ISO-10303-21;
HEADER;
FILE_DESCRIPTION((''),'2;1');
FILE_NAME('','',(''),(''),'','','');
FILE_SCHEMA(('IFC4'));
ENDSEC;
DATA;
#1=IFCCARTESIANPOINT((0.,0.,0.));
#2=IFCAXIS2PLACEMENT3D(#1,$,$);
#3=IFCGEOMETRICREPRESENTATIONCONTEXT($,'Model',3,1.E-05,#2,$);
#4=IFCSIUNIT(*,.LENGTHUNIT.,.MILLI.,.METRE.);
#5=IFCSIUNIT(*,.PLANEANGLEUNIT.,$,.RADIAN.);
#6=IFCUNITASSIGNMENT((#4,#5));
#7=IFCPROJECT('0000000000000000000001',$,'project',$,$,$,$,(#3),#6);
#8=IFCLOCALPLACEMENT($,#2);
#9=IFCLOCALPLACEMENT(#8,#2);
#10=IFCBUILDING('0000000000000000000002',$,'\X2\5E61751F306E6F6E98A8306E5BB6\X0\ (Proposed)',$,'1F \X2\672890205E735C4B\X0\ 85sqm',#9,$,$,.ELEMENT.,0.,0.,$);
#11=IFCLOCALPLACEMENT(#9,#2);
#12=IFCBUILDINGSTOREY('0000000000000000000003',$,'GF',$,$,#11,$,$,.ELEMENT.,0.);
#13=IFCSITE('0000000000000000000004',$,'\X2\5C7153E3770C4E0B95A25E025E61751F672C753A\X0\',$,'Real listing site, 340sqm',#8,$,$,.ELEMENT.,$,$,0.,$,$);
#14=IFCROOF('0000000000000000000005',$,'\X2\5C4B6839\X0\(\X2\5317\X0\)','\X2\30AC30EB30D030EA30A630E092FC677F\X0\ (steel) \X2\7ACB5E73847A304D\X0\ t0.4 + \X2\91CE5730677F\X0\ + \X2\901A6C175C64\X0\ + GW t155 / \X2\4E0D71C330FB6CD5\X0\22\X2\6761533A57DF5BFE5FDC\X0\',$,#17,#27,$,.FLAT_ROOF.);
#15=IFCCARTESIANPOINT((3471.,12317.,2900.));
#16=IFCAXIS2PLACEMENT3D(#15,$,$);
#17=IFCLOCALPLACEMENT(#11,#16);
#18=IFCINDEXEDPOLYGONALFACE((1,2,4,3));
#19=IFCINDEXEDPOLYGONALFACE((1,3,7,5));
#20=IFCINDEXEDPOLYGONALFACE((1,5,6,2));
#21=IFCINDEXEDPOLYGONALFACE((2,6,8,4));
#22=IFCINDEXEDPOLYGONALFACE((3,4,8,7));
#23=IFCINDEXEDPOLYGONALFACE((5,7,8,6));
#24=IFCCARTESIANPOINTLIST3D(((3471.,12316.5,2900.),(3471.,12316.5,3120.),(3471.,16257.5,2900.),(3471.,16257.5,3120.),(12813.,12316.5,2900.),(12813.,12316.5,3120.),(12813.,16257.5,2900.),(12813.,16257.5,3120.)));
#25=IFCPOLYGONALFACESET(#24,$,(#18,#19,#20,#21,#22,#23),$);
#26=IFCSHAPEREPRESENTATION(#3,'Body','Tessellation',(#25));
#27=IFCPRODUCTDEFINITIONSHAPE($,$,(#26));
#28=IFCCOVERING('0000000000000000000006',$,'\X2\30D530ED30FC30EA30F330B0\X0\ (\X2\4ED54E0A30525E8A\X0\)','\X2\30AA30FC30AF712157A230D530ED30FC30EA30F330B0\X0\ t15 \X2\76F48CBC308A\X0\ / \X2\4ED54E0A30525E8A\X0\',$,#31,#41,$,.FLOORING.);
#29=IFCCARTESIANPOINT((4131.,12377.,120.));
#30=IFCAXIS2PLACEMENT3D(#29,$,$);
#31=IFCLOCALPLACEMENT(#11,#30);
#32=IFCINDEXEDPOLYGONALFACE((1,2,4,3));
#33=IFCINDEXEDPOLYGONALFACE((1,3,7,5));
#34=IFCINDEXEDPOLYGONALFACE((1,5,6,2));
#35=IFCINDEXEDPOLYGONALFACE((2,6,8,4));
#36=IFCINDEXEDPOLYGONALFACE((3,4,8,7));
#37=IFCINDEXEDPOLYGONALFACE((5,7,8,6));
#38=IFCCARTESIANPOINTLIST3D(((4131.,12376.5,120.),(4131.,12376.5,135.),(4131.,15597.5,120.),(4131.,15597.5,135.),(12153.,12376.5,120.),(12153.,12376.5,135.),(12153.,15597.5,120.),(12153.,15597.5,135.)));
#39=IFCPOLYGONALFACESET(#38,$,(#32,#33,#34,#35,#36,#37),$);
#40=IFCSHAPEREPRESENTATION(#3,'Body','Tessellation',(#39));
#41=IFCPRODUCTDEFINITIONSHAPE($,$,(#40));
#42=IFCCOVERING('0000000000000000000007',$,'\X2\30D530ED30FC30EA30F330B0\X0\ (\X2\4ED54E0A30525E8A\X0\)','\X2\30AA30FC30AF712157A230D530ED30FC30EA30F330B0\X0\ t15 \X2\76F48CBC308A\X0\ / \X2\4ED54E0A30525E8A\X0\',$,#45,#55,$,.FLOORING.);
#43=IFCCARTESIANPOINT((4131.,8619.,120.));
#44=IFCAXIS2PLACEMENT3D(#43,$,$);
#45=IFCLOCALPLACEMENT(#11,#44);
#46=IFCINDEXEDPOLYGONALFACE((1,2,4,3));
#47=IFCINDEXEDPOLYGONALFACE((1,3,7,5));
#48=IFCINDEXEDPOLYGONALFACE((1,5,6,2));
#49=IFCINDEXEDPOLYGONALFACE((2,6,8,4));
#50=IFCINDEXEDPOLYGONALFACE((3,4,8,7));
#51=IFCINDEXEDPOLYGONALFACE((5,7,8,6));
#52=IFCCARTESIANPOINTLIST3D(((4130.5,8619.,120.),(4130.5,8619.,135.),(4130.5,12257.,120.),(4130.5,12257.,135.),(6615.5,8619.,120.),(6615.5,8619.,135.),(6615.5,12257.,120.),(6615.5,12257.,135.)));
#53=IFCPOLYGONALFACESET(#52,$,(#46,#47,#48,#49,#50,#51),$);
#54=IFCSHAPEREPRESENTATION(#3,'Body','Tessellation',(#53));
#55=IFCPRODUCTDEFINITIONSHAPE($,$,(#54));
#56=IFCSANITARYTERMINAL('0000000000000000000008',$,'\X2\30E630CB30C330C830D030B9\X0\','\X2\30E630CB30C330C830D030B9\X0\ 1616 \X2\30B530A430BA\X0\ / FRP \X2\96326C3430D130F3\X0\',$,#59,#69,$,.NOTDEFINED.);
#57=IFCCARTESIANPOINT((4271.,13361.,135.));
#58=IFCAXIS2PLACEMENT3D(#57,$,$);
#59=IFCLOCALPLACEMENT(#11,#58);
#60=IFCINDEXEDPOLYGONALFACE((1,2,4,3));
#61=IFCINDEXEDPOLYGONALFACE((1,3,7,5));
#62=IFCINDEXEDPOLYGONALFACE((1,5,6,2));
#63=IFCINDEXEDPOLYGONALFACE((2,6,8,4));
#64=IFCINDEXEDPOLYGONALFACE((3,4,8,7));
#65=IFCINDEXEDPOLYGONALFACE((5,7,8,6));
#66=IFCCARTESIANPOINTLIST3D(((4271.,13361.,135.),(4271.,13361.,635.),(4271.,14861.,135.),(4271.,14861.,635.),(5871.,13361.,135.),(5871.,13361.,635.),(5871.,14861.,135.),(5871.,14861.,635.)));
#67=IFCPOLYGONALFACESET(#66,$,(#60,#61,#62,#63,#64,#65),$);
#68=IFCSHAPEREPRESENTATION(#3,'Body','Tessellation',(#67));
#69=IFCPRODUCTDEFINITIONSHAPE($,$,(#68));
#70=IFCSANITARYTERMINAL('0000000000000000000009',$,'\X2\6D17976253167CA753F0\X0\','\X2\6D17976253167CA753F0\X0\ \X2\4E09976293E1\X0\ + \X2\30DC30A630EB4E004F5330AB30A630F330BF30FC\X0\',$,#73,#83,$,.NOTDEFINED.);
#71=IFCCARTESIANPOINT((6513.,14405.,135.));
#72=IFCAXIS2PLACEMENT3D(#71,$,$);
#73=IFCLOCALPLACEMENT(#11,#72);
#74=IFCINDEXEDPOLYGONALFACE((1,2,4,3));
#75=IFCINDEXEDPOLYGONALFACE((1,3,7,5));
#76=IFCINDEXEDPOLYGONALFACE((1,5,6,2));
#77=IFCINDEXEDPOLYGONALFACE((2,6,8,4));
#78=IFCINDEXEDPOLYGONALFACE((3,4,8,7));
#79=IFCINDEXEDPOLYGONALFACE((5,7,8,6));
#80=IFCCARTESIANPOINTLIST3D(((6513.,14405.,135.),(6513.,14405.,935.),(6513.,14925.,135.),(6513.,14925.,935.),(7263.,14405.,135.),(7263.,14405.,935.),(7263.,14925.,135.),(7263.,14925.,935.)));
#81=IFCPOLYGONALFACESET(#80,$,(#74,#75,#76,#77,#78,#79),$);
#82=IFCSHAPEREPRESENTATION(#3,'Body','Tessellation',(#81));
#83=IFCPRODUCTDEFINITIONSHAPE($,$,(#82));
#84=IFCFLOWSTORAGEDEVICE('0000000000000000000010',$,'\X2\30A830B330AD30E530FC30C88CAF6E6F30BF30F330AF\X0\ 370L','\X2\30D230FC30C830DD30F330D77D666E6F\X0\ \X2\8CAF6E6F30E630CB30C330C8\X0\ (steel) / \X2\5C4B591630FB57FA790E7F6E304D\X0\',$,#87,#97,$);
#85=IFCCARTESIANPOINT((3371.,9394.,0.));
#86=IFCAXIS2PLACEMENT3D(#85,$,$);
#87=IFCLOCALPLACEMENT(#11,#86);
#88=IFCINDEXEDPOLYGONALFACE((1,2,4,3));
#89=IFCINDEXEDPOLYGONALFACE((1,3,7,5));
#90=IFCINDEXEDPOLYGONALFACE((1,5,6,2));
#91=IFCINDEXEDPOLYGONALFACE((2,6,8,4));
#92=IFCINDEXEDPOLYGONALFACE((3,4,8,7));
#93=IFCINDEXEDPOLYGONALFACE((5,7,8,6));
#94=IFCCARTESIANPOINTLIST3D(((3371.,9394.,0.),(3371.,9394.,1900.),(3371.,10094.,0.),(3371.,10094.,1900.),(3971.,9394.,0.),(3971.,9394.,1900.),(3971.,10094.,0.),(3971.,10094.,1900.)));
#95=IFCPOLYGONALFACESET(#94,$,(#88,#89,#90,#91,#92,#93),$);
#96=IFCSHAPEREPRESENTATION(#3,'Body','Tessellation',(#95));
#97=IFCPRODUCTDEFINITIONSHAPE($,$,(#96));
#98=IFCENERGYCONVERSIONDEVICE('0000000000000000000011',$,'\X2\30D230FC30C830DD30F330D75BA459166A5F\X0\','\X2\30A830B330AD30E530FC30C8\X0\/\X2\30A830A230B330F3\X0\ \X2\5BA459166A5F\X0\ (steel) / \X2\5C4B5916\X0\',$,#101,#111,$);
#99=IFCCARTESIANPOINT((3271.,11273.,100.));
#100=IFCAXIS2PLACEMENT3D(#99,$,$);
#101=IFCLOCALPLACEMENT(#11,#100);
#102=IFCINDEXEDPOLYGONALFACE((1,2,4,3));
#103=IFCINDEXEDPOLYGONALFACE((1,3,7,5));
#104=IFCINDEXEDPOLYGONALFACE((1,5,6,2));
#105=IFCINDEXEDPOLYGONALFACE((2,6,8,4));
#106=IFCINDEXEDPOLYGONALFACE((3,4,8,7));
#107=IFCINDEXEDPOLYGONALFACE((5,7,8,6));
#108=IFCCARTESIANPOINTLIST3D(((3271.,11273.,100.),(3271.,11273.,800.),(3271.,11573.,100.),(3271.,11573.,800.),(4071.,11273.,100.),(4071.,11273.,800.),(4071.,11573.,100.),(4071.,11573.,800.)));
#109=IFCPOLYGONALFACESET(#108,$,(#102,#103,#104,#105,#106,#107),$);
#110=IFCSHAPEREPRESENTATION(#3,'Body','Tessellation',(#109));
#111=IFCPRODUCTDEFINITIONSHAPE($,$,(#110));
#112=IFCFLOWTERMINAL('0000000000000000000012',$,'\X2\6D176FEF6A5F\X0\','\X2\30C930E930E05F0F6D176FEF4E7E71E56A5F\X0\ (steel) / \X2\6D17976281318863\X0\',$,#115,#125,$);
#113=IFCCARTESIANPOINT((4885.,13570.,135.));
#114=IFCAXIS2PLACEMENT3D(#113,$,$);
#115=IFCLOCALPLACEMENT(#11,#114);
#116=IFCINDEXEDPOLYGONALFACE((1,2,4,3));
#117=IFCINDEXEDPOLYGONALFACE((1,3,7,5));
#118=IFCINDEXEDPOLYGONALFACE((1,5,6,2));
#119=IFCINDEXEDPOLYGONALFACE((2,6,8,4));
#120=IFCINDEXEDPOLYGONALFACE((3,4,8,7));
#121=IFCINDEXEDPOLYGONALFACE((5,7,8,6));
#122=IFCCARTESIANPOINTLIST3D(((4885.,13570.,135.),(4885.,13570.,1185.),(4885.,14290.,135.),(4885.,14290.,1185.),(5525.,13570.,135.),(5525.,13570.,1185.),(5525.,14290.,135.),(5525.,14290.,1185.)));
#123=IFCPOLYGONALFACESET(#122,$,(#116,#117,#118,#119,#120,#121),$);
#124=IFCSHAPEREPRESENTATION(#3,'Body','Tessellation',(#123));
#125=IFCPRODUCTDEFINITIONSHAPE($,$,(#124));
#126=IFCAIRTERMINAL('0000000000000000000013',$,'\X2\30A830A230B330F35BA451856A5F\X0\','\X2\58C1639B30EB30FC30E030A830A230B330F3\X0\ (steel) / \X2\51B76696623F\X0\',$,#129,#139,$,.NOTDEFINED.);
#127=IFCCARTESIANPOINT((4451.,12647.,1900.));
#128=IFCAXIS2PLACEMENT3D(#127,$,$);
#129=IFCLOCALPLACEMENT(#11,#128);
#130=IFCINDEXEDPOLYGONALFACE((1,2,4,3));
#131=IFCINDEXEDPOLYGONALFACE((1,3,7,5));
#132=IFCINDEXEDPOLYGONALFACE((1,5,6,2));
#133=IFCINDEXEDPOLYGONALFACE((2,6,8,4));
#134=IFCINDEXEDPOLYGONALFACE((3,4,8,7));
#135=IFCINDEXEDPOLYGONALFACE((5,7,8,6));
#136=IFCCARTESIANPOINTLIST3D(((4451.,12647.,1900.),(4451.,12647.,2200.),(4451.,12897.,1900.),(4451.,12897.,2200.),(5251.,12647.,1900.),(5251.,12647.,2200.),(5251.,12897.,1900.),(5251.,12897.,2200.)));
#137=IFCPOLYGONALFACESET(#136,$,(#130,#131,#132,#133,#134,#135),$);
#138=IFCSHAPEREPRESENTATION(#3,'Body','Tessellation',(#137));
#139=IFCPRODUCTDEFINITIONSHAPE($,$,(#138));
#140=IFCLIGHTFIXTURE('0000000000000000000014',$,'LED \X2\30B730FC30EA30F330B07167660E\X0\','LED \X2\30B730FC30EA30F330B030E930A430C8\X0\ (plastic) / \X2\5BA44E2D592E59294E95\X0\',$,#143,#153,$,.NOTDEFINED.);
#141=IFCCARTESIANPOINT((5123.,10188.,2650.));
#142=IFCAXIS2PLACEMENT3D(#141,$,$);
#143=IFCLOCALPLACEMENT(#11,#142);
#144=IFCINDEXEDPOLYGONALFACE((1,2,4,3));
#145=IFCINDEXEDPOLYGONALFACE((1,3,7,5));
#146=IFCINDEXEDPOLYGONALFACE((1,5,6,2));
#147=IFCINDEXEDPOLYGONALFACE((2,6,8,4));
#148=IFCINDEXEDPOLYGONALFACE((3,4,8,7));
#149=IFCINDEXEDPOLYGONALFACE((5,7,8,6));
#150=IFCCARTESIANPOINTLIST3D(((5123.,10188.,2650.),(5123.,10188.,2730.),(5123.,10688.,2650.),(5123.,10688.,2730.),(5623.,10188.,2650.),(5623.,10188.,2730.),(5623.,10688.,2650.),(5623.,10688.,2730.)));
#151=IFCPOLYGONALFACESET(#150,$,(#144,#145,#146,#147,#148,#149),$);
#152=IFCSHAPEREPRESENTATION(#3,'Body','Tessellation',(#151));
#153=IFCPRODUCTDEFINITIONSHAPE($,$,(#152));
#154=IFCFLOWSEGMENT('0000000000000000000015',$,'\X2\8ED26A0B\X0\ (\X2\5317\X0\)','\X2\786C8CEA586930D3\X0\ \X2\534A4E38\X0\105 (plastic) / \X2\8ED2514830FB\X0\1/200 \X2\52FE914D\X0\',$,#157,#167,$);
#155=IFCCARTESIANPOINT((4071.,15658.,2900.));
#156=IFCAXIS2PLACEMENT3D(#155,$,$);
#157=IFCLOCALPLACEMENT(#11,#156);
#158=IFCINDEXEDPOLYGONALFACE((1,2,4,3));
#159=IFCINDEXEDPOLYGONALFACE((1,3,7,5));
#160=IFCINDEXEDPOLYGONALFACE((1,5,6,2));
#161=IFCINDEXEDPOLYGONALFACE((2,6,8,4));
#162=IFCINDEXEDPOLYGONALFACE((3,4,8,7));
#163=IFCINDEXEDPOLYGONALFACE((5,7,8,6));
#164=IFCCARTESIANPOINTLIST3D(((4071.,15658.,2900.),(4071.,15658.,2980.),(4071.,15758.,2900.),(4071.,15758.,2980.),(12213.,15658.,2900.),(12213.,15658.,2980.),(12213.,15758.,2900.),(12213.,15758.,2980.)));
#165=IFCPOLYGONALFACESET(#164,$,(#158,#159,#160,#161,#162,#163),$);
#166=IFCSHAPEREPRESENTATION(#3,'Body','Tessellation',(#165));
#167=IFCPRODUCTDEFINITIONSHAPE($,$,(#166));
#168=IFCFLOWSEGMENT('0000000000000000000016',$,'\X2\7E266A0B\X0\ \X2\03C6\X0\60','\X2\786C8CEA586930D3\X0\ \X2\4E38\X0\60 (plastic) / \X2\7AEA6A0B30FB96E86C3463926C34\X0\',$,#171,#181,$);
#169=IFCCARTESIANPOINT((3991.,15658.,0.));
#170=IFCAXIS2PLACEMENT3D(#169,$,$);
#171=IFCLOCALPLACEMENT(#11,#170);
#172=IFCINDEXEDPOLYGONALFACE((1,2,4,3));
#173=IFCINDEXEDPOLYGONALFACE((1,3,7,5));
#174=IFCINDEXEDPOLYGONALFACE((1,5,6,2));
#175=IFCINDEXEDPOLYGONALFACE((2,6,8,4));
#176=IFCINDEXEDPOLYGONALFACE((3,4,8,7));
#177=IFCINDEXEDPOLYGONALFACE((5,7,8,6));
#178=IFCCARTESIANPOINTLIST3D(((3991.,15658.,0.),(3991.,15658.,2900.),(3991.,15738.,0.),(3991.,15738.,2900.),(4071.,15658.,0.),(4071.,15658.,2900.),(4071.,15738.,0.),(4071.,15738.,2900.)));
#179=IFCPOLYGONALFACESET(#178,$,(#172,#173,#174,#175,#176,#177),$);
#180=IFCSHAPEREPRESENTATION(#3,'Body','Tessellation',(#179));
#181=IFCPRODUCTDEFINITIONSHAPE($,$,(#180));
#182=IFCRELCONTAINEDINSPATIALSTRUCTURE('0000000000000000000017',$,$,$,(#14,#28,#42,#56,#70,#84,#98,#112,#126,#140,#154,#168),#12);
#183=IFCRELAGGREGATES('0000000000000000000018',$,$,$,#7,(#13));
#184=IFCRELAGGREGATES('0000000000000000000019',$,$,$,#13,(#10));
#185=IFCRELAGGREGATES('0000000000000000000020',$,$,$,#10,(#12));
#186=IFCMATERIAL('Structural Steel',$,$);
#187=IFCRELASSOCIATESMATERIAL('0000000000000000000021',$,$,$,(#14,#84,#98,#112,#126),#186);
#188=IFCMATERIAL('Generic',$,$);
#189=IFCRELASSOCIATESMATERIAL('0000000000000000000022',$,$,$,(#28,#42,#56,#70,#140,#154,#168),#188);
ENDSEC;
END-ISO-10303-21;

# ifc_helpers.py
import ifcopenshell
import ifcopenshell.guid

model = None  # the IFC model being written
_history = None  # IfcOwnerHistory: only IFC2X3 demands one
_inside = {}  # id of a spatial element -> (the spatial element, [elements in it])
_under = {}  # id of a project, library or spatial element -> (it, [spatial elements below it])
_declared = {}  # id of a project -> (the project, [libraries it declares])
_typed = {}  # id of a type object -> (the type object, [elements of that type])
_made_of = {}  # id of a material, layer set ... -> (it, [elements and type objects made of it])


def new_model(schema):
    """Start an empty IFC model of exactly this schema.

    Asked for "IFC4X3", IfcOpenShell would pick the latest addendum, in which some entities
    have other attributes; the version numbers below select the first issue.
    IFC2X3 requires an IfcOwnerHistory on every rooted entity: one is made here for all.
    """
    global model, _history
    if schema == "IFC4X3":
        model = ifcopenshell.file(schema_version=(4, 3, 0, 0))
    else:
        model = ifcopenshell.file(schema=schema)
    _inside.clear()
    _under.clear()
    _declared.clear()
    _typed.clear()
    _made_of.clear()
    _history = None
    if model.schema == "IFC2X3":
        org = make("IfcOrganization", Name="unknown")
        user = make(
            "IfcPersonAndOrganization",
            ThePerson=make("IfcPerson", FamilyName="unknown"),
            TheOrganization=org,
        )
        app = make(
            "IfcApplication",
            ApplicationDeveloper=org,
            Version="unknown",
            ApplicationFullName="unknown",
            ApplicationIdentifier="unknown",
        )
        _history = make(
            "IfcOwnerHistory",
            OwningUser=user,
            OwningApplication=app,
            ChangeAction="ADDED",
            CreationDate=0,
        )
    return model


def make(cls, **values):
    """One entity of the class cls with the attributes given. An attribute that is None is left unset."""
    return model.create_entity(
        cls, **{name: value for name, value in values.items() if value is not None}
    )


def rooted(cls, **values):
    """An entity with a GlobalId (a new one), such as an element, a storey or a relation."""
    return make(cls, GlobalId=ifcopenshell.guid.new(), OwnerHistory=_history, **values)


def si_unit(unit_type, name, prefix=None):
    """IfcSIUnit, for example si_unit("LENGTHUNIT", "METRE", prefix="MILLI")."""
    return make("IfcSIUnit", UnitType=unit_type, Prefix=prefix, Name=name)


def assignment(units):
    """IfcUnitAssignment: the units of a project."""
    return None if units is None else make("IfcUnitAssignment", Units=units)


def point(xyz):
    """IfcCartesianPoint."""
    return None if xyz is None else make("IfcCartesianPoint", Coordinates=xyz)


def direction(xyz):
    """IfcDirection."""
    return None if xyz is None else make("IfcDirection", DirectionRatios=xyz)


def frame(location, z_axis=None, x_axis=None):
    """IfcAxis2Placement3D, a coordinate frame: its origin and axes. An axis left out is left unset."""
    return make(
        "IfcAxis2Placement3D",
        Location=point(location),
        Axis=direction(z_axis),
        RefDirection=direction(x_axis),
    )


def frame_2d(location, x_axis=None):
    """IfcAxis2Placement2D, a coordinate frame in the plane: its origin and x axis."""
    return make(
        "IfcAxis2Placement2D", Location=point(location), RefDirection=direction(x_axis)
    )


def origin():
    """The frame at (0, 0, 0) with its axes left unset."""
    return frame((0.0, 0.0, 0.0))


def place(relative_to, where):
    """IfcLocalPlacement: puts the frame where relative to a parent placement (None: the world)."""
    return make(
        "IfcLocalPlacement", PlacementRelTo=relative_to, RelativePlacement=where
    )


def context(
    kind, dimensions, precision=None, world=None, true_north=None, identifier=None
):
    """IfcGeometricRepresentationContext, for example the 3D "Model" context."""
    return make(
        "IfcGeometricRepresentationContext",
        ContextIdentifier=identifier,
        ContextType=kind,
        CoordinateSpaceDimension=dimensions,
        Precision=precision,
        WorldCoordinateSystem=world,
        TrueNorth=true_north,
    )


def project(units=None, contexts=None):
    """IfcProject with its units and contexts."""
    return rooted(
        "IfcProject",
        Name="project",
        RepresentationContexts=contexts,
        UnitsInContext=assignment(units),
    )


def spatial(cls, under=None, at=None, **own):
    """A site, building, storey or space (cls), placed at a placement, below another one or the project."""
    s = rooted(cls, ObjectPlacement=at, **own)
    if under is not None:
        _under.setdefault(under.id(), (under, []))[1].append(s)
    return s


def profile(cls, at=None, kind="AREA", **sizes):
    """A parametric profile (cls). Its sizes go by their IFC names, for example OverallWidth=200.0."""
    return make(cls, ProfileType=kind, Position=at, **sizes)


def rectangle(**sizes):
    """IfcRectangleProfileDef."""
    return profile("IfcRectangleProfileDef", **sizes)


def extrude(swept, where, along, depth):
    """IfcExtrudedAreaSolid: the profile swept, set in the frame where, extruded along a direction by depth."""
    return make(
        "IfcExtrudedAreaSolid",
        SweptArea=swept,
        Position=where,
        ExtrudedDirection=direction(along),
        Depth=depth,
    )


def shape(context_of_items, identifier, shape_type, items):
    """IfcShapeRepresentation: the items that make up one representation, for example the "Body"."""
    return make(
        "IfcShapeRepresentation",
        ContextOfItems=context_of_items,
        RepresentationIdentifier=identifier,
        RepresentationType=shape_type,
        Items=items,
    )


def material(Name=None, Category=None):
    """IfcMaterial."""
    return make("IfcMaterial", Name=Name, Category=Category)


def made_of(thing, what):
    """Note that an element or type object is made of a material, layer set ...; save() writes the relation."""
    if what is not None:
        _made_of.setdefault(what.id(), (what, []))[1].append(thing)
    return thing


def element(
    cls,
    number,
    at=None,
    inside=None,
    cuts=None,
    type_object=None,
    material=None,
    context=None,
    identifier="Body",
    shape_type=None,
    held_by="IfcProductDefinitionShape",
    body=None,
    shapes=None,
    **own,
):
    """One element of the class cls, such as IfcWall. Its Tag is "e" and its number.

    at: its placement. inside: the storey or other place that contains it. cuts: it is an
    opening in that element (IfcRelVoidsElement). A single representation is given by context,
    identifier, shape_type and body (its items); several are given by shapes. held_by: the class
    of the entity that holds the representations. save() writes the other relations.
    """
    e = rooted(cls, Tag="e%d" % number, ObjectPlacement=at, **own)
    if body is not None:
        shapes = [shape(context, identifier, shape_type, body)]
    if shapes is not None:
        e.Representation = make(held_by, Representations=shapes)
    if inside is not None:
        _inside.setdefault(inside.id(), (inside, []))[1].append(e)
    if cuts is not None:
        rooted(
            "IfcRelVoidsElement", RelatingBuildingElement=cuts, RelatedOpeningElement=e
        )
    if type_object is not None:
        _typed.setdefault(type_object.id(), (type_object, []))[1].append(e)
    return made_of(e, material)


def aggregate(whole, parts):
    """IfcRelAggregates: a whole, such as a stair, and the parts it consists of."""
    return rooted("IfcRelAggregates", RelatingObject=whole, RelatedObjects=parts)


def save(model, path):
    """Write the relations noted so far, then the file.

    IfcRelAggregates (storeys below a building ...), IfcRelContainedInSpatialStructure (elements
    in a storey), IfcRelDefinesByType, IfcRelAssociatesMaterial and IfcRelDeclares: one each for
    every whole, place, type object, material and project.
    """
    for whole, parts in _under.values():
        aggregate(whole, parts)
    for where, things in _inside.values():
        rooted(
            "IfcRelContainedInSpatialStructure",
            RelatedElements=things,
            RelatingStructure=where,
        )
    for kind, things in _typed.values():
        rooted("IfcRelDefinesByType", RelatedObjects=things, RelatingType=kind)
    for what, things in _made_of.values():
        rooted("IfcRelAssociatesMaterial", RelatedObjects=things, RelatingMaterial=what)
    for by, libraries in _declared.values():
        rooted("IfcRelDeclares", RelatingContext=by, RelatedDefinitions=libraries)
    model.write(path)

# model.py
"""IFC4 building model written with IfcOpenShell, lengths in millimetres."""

from ifc_helpers import new_model, si_unit, frame, frame_2d, origin, place, context, project, spatial, rectangle, extrude, material, element, save


model = new_model("IFC4")

# Units and contexts
model_context = context("Model", 3, precision=1e-05, world=origin())
ifc_project = project(units=[si_unit("LENGTHUNIT", "METRE", prefix="MILLI"), si_unit("PLANEANGLEUNIT", "RADIAN")], contexts=[model_context])

# Site, building, storey
site_placement = place(None, origin())
site = spatial("IfcSite", under=ifc_project, at=site_placement, Name="山口県下関市幡生本町", ObjectType="Real listing site, 340sqm", CompositionType="ELEMENT", RefElevation=0.0)
building_placement = place(site_placement, origin())
building = spatial("IfcBuilding", under=site, at=building_placement, Name="幡生の潮風の家 (Proposed)", ObjectType="1F 木造平屋 85sqm", CompositionType="ELEMENT", ElevationOfRefHeight=0.0, ElevationOfTerrain=0.0)
storey_placement = place(building_placement, origin())
storey = spatial("IfcBuildingStorey", under=building, at=storey_placement, Name="GF", CompositionType="ELEMENT", Elevation=0.0)

# Roof
ifc_material_1 = material(Name="Structural Steel")
roof_placement = place(storey_placement, frame((3471.0, 12317.0, 2900.0)))
element("IfcRoof", 1, at=roof_placement, inside=storey, material=ifc_material_1, Name="屋根(北)", Description="ガルバリウム鋼板 (steel) 立平葺き t0.4 + 野地板 + 通気層 + GW t155 / 不燃・法22条区域対応", PredefinedType="FLAT_ROOF", context=model_context, shape_type="SweptSolid", body=[
    extrude(rectangle(XDim=9342.0, YDim=3941.0, at=frame_2d((4671.0, 1970.0))), frame((3471.0, 12317.0, 2900.0)), (0.0, 0.0, 1.0), 220.0),
])

# Coverings
ifc_material_2 = material(Name="Generic")
covering_1_placement = place(storey_placement, frame((4131.0, 12377.0, 120.0)))
element("IfcCovering", 2, at=covering_1_placement, inside=storey, material=ifc_material_2, Name="フローリング (仕上げ床)", Description="オーク無垢フローリング t15 直貼り / 仕上げ床", PredefinedType="FLOORING", context=model_context, shape_type="SweptSolid", body=[
    extrude(rectangle(XDim=8022.0, YDim=3221.0, at=frame_2d((4011.0, 1610.0))), frame((4131.0, 12377.0, 120.0)), (0.0, 0.0, 1.0), 15.0),
])
covering_2_placement = place(storey_placement, frame((4131.0, 8619.0, 120.0)))
element("IfcCovering", 3, at=covering_2_placement, inside=storey, material=ifc_material_2, Name="フローリング (仕上げ床)", Description="オーク無垢フローリング t15 直貼り / 仕上げ床", PredefinedType="FLOORING", context=model_context, shape_type="SweptSolid", body=[
    extrude(rectangle(XDim=2485.0, YDim=3638.0, at=frame_2d((1242.0, 1819.0))), frame((4131.0, 8619.0, 120.0)), (0.0, 0.0, 1.0), 15.0),
])

# Sanitary terminals
sanitary_terminal_1_placement = place(storey_placement, frame((4271.0, 13361.0, 135.0)))
element("IfcSanitaryTerminal", 4, at=sanitary_terminal_1_placement, inside=storey, material=ifc_material_2, Name="ユニットバス", Description="ユニットバス 1616 サイズ / FRP 防水パン", PredefinedType="NOTDEFINED", context=model_context, shape_type="SweptSolid", body=[
    extrude(rectangle(XDim=1600.0, YDim=1500.0, at=frame_2d((800.0, 750.0))), frame((4271.0, 13361.0, 135.0)), (0.0, 0.0, 1.0), 500.0),
])
sanitary_terminal_2_placement = place(storey_placement, frame((6513.0, 14405.0, 135.0)))
element("IfcSanitaryTerminal", 5, at=sanitary_terminal_2_placement, inside=storey, material=ifc_material_2, Name="洗面化粧台", Description="洗面化粧台 三面鏡 + ボウル一体カウンター", PredefinedType="NOTDEFINED", context=model_context, shape_type="SweptSolid", body=[
    extrude(rectangle(XDim=750.0, YDim=520.0, at=frame_2d((375.0, 260.0))), frame((6513.0, 14405.0, 135.0)), (0.0, 0.0, 1.0), 800.0),
])

# Flow storage device
flow_storage_device_placement = place(storey_placement, frame((3371.0, 9394.0, 0.0)))
element("IfcFlowStorageDevice", 6, at=flow_storage_device_placement, inside=storey, material=ifc_material_1, Name="エコキュート貯湯タンク 370L", Description="ヒートポンプ給湯 貯湯ユニット (steel) / 屋外・基礎置き", context=model_context, shape_type="SweptSolid", body=[
    extrude(rectangle(XDim=600.0, YDim=700.0, at=frame_2d((300.0, 350.0))), frame((3371.0, 9394.0, 0.0)), (0.0, 0.0, 1.0), 1900.0),
])

# Energy conversion device
energy_conversion_device_placement = place(storey_placement, frame((3271.0, 11273.0, 100.0)))
element("IfcEnergyConversionDevice", 7, at=energy_conversion_device_placement, inside=storey, material=ifc_material_1, Name="ヒートポンプ室外機", Description="エコキュート/エアコン 室外機 (steel) / 屋外", context=model_context, shape_type="SweptSolid", body=[
    extrude(rectangle(XDim=800.0, YDim=300.0, at=frame_2d((400.0, 150.0))), frame((3271.0, 11273.0, 100.0)), (0.0, 0.0, 1.0), 700.0),
])

# Flow terminal
flow_terminal_placement = place(storey_placement, frame((4885.0, 13570.0, 135.0)))
element("IfcFlowTerminal", 8, at=flow_terminal_placement, inside=storey, material=ifc_material_1, Name="洗濯機", Description="ドラム式洗濯乾燥機 (steel) / 洗面脱衣", context=model_context, shape_type="SweptSolid", body=[
    extrude(rectangle(XDim=640.0, YDim=720.0, at=frame_2d((320.0, 360.0))), frame((4885.0, 13570.0, 135.0)), (0.0, 0.0, 1.0), 1050.0),
])

# Air terminal
air_terminal_placement = place(storey_placement, frame((4451.0, 12647.0, 1900.0)))
element("IfcAirTerminal", 9, at=air_terminal_placement, inside=storey, material=ifc_material_1, Name="エアコン室内機", Description="壁掛ルームエアコン (steel) / 冷暖房", PredefinedType="NOTDEFINED", context=model_context, shape_type="SweptSolid", body=[
    extrude(rectangle(XDim=800.0, YDim=250.0, at=frame_2d((400.0, 125.0))), frame((4451.0, 12647.0, 1900.0)), (0.0, 0.0, 1.0), 300.0),
])

# Light fixture
light_fixture_placement = place(storey_placement, frame((5123.0, 10188.0, 2650.0)))
element("IfcLightFixture", 10, at=light_fixture_placement, inside=storey, material=ifc_material_2, Name="LED シーリング照明", Description="LED シーリングライト (plastic) / 室中央天井", PredefinedType="NOTDEFINED", context=model_context, shape_type="SweptSolid", body=[
    extrude(rectangle(XDim=500.0, YDim=500.0, at=frame_2d((250.0, 250.0))), frame((5123.0, 10188.0, 2650.0)), (0.0, 0.0, 1.0), 80.0),
])

# Flow segments
flow_segment_1_placement = place(storey_placement, frame((4071.0, 15658.0, 2900.0)))
element("IfcFlowSegment", 11, at=flow_segment_1_placement, inside=storey, material=ifc_material_2, Name="軒樋 (北)", Description="硬質塩ビ 半丸105 (plastic) / 軒先・1/200 勾配", context=model_context, shape_type="SweptSolid", body=[
    extrude(rectangle(XDim=8142.0, YDim=100.0, at=frame_2d((4071.0, 50.0))), frame((4071.0, 15658.0, 2900.0)), (0.0, 0.0, 1.0), 80.0),
])
flow_segment_2_placement = place(storey_placement, frame((3991.0, 15658.0, 0.0)))
element("IfcFlowSegment", 12, at=flow_segment_2_placement, inside=storey, material=ifc_material_2, Name="縦樋 φ60", Description="硬質塩ビ 丸60 (plastic) / 竪樋・雨水排水", context=model_context, shape_type="SweptSolid", body=[
    extrude(rectangle(XDim=80.0, YDim=80.0, at=frame_2d((40.0, 40.0))), frame((3991.0, 15658.0, 0.0)), (0.0, 0.0, 1.0), 2900.0),
])

save(model, "model.ifc")
